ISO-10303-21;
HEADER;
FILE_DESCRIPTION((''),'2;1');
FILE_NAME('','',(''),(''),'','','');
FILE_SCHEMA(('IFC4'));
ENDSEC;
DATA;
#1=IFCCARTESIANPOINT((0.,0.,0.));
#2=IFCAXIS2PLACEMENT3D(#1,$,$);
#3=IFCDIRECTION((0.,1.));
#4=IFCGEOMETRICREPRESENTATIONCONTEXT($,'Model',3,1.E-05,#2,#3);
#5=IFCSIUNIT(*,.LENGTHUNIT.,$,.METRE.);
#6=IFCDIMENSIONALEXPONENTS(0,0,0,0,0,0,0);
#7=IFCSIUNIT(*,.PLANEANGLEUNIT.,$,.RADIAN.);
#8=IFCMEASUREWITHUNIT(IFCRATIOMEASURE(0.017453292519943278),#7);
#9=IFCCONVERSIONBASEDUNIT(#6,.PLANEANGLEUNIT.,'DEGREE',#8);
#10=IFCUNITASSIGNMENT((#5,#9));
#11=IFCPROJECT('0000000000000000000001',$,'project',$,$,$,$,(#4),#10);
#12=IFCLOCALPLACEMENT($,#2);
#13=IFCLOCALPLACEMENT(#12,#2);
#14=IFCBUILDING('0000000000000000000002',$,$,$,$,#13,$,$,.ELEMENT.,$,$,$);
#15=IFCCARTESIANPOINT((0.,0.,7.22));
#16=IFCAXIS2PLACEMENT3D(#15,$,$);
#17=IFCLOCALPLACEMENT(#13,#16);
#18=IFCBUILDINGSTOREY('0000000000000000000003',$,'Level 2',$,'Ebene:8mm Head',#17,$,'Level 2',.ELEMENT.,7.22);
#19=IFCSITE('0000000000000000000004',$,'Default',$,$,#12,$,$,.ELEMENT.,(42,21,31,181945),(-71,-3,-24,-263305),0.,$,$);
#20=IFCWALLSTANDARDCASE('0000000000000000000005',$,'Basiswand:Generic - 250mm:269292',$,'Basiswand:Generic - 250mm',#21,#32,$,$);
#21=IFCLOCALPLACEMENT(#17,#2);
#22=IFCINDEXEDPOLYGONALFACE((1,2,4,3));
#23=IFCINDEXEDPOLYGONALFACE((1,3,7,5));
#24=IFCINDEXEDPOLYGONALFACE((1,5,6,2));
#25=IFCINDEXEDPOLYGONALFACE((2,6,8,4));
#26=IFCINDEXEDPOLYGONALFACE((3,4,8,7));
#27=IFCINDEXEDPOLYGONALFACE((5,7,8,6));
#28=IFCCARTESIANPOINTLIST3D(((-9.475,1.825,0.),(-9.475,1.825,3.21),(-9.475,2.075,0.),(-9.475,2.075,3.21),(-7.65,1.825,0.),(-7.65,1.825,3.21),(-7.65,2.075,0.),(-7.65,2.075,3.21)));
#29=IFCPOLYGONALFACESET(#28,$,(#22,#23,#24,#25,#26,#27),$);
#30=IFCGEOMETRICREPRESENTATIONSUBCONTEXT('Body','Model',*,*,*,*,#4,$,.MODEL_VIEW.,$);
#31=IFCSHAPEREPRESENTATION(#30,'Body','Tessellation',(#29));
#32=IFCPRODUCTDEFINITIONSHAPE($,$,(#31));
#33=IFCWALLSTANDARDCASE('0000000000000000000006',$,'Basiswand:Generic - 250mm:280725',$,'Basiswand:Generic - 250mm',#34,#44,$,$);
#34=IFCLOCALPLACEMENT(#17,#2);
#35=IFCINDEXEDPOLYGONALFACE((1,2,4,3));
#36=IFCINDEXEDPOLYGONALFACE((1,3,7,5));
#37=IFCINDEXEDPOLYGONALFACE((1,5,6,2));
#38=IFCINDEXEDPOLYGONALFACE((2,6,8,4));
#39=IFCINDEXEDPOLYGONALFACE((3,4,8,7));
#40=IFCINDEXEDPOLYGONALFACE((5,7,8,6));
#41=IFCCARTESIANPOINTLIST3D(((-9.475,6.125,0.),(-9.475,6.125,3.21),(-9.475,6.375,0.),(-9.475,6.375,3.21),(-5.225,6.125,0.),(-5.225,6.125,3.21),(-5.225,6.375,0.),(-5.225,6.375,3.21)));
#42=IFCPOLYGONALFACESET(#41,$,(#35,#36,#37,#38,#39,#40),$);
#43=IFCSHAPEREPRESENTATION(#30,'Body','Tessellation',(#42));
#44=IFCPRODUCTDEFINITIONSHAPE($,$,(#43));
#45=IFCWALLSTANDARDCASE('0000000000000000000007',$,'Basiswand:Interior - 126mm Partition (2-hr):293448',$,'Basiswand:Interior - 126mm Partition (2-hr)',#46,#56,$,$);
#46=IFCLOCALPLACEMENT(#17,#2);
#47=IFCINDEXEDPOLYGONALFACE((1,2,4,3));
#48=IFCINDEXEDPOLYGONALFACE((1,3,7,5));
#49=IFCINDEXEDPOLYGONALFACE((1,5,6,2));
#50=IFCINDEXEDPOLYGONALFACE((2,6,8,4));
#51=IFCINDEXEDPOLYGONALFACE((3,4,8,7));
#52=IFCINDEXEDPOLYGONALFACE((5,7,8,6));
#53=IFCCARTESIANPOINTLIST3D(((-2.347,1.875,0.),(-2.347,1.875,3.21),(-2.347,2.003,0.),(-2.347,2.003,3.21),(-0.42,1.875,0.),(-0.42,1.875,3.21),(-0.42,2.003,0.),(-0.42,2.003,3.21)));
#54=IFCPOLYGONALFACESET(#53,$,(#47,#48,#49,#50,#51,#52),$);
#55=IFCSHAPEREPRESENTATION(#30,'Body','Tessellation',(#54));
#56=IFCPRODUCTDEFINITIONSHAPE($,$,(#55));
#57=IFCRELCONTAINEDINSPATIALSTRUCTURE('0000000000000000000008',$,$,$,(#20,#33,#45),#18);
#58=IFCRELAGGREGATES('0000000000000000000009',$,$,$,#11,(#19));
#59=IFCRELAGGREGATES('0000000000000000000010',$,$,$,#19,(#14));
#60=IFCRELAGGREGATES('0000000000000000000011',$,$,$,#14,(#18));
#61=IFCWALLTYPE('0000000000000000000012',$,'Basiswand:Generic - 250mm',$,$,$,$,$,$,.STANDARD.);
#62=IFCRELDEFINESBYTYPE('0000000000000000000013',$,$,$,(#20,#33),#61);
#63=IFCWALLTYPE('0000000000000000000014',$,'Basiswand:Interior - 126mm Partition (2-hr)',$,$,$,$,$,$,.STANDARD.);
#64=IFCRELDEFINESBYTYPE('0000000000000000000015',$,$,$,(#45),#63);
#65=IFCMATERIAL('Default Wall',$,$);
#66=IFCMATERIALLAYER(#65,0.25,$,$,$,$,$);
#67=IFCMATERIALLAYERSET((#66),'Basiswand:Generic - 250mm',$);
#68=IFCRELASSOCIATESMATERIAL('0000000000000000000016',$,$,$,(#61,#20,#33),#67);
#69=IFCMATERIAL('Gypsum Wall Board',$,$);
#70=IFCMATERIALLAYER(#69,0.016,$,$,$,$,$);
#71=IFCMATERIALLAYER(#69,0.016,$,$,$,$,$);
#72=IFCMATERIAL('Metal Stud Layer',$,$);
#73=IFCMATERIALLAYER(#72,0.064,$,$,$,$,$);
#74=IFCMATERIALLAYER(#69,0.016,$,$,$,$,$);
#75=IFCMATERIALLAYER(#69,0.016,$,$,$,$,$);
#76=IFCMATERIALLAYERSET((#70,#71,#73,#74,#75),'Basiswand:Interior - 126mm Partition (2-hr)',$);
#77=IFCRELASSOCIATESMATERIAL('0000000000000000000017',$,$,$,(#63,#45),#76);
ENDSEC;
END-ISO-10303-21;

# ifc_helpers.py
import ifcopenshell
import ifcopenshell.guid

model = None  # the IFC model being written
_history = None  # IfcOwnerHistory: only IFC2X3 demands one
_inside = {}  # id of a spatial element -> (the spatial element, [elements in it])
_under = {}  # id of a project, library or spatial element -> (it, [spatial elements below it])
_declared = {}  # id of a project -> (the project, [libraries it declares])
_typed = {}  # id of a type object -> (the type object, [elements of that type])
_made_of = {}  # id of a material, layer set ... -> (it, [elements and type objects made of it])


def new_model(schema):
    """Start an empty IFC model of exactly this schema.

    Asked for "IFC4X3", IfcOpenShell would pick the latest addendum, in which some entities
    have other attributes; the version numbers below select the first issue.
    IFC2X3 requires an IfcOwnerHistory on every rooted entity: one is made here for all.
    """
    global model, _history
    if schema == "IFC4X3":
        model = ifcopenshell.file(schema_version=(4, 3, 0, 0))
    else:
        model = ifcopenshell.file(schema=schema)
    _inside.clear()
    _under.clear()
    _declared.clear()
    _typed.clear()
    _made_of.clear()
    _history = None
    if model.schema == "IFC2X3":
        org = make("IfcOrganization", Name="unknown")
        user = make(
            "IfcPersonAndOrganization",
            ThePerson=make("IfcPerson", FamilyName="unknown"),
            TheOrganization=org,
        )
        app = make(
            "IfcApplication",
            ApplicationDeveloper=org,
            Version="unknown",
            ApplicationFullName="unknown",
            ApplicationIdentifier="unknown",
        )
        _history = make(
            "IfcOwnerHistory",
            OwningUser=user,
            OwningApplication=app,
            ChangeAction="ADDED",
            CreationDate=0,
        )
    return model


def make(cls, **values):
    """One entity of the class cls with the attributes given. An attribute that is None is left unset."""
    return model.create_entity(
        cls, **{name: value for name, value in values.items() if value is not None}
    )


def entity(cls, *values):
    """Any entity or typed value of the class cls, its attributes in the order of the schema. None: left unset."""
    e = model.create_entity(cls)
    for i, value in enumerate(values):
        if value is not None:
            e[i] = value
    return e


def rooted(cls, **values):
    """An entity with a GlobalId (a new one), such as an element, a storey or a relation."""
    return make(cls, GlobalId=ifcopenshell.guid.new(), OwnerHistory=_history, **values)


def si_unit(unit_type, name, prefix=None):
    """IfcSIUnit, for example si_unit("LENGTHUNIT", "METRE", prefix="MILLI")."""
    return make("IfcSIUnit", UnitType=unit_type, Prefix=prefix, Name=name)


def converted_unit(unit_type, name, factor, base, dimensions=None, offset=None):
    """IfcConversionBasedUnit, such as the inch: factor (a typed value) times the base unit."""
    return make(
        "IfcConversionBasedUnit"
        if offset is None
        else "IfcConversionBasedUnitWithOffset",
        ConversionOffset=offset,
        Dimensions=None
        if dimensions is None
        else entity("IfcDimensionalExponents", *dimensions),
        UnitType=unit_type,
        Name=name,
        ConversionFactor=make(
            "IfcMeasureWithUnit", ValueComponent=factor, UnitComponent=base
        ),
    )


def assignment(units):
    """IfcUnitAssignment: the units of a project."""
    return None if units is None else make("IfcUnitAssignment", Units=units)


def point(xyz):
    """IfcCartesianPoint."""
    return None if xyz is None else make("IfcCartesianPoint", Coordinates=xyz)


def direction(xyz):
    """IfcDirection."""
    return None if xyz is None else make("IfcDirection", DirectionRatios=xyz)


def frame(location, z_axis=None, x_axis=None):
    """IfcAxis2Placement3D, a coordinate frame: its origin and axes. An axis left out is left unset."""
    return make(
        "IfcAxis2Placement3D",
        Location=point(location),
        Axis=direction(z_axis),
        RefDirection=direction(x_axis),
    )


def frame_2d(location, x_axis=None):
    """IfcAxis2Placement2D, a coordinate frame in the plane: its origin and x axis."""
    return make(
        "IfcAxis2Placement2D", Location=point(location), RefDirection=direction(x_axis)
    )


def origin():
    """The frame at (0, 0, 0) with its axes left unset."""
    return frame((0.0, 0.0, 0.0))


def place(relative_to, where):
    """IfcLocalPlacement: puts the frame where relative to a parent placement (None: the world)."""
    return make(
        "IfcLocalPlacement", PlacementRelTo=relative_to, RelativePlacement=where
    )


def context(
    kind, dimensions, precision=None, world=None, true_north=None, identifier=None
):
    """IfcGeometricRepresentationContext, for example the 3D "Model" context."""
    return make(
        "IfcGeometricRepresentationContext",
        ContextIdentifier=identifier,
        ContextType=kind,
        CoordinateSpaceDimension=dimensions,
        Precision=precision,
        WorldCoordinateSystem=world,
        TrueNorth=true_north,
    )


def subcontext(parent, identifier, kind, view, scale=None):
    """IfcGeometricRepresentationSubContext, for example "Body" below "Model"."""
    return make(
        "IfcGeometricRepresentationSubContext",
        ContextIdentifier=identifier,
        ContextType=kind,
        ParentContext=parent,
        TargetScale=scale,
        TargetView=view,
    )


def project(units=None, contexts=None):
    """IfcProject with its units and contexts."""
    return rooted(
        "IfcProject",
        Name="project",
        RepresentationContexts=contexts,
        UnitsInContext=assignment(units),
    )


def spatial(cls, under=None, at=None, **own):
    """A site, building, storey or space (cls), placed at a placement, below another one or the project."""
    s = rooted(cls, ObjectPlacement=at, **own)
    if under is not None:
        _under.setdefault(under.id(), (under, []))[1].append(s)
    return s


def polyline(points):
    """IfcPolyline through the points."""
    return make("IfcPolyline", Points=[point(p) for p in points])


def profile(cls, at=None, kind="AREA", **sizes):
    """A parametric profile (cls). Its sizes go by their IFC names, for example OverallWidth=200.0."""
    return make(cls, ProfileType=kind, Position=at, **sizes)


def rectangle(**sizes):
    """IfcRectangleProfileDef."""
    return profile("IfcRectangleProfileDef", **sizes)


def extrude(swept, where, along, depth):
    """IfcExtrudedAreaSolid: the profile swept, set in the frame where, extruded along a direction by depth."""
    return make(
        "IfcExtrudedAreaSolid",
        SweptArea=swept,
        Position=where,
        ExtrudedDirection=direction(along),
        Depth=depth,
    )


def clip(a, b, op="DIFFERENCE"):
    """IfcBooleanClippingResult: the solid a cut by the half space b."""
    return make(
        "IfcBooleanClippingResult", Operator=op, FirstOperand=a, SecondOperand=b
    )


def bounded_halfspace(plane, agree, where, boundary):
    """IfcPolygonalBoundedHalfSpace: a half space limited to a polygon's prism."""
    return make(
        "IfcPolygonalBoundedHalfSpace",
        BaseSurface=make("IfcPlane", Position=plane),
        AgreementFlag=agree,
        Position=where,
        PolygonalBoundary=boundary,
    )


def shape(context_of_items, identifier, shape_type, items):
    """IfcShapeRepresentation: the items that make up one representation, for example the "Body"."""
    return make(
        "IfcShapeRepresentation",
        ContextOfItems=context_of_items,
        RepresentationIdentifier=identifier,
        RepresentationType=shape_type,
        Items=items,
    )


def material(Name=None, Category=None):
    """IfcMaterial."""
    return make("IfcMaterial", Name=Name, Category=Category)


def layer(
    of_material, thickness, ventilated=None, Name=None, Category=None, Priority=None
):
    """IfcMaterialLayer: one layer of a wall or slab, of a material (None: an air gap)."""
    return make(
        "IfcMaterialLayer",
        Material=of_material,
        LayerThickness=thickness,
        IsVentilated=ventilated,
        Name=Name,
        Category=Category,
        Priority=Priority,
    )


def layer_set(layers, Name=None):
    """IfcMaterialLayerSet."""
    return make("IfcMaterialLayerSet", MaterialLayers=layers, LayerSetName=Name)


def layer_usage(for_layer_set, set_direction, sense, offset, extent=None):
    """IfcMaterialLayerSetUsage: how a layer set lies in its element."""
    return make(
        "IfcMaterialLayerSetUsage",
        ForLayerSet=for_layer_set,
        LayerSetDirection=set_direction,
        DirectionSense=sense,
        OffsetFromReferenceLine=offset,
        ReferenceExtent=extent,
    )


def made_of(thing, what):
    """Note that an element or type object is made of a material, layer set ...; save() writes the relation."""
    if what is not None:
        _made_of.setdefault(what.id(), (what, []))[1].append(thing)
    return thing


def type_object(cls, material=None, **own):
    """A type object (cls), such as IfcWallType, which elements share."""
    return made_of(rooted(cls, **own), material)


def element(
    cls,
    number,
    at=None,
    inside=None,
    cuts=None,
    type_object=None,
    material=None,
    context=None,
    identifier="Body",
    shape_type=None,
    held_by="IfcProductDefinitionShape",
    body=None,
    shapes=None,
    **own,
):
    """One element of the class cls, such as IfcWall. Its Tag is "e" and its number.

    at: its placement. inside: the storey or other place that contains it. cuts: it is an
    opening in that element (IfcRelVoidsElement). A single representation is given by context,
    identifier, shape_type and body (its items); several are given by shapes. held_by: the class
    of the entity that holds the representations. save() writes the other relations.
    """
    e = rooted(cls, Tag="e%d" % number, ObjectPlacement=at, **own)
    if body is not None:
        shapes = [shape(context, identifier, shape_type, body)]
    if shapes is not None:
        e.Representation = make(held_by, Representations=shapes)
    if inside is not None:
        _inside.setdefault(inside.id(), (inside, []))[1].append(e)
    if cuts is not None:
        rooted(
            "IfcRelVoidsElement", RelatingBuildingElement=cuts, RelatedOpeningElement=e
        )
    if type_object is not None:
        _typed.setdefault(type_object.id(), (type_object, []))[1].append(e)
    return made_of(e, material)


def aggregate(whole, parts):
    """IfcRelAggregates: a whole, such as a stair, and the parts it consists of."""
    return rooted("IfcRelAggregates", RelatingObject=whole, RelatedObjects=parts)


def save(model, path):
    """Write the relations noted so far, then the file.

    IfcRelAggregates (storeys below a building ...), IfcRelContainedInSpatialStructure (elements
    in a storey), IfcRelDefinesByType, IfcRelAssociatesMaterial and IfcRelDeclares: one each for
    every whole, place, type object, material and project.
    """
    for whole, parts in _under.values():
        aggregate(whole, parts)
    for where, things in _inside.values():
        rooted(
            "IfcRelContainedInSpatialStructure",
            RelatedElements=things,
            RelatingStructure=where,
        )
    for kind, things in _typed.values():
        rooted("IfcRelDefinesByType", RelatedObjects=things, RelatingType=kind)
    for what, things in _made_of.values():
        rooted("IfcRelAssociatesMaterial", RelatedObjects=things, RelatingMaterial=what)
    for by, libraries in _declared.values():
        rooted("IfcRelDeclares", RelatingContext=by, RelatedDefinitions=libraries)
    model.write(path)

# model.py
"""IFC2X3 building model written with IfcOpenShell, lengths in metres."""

from ifc_helpers import new_model, entity, si_unit, converted_unit, direction, frame, frame_2d, origin, place, context, subcontext, project, spatial, polyline, rectangle, extrude, clip, bounded_halfspace, material, layer, layer_set, layer_usage, type_object, element, save


model = new_model("IFC2X3")

# Units and contexts
model_context = context("Model", 3, precision=1e-05, world=origin(), true_north=direction((0.0, 1.0)))
body_context = subcontext(model_context, "Body", "Model", "MODEL_VIEW")
ifc_project = project(units=[si_unit("LENGTHUNIT", "METRE"), converted_unit("PLANEANGLEUNIT", "DEGREE", entity("IfcRatioMeasure", 0.017453292519943278), si_unit("PLANEANGLEUNIT", "RADIAN"), dimensions=[0, 0, 0, 0, 0, 0, 0])], contexts=[model_context])

# Site, building, storey
site_placement = place(None, origin())
site = spatial("IfcSite", under=ifc_project, at=site_placement, Name="Default", CompositionType="ELEMENT", RefLatitude=(42, 21, 31, 181945), RefLongitude=(-71, -3, -24, -263305), RefElevation=0.0)
building_placement = place(site_placement, origin())
building = spatial("IfcBuilding", under=site, at=building_placement, CompositionType="ELEMENT")
storey_placement = place(building_placement, frame((0.0, 0.0, 7.22)))
storey = spatial("IfcBuildingStorey", under=building, at=storey_placement, Name="Level 2", ObjectType="Ebene:8mm Head", LongName="Level 2", CompositionType="ELEMENT", Elevation=7.22)

# Walls
ifc_material_1 = material(Name="Default Wall")
ifc_layer_1 = layer(ifc_material_1, 0.25)
ifc_layer_set_1 = layer_set([ifc_layer_1], Name="Basiswand:Generic - 250mm")
ifc_layer_usage_1 = layer_usage(ifc_layer_set_1, "AXIS2", "NEGATIVE", 0.125)
wall_type_1 = type_object("IfcWallType", Name="Basiswand:Generic - 250mm", PredefinedType="STANDARD", material=ifc_layer_set_1)
wall_1_placement = place(storey_placement, frame((-7.65, 1.95, 0.0), z_axis=(0.0, 0.0, 1.0), x_axis=(-1.0, 0.0, 0.0)))
element("IfcWallStandardCase", 1, at=wall_1_placement, inside=storey, type_object=wall_type_1, material=ifc_layer_usage_1, Name="Basiswand:Generic - 250mm:269292", ObjectType="Basiswand:Generic - 250mm", context=body_context, shape_type="SweptSolid", body=[
    extrude(rectangle(XDim=1.825, YDim=0.25, at=frame_2d((0.9125, 0.0), x_axis=(-1.0, 0.0))), origin(), (0.0, 0.0, 1.0), 3.21),
])
wall_2_placement = place(storey_placement, frame((-5.225, 6.25, 0.0), z_axis=(0.0, 0.0, 1.0), x_axis=(-1.0, 0.0, 0.0)))
element("IfcWallStandardCase", 2, at=wall_2_placement, inside=storey, type_object=wall_type_1, material=ifc_layer_usage_1, Name="Basiswand:Generic - 250mm:280725", ObjectType="Basiswand:Generic - 250mm", context=body_context, shape_type="SweptSolid", body=[
    extrude(rectangle(XDim=4.25, YDim=0.25, at=frame_2d((2.125, 0.0), x_axis=(-1.0, 0.0))), origin(), (0.0, 0.0, 1.0), 3.21),
])
ifc_material_2 = material(Name="Gypsum Wall Board")
ifc_layer_2 = layer(ifc_material_2, 0.016)
ifc_layer_3 = layer(ifc_material_2, 0.016)
ifc_material_3 = material(Name="Metal Stud Layer")
ifc_layer_4 = layer(ifc_material_3, 0.064)
ifc_layer_5 = layer(ifc_material_2, 0.016)
ifc_layer_6 = layer(ifc_material_2, 0.016)
ifc_layer_set_2 = layer_set([ifc_layer_2, ifc_layer_3, ifc_layer_4, ifc_layer_5, ifc_layer_6], Name="Basiswand:Interior - 126mm Partition (2-hr)")
ifc_layer_usage_2 = layer_usage(ifc_layer_set_2, "AXIS2", "NEGATIVE", 0.064)
wall_type_2 = type_object("IfcWallType", Name="Basiswand:Interior - 126mm Partition (2-hr)", PredefinedType="STANDARD", material=ifc_layer_set_2)
wall_3_placement = place(storey_placement, frame((-2.347, 1.939, 0.0)))
element("IfcWallStandardCase", 3, at=wall_3_placement, inside=storey, type_object=wall_type_2, material=ifc_layer_usage_2, Name="Basiswand:Interior - 126mm Partition (2-hr):293448", ObjectType="Basiswand:Interior - 126mm Partition (2-hr)", context=body_context, shape_type="Clipping", body=[
    clip(extrude(rectangle(XDim=1.927, YDim=0.128, at=frame_2d((0.9635, 0.0), x_axis=(-1.0, 0.0))), origin(), (0.0, 0.0, 1.0), 3.21), bounded_halfspace(frame((0.0, -0.064, 3.21), z_axis=(0.0, 0.0, -1.0), x_axis=(0.0, 1.0, 0.0)), True, frame((0.0, -0.064, 3.21)), polyline([(0.0, 0.0), (1.927, 0.0), (1.927, 0.128), (0.0, 0.128), (0.0, 0.0)]))),
])

save(model, "model.ifc")
